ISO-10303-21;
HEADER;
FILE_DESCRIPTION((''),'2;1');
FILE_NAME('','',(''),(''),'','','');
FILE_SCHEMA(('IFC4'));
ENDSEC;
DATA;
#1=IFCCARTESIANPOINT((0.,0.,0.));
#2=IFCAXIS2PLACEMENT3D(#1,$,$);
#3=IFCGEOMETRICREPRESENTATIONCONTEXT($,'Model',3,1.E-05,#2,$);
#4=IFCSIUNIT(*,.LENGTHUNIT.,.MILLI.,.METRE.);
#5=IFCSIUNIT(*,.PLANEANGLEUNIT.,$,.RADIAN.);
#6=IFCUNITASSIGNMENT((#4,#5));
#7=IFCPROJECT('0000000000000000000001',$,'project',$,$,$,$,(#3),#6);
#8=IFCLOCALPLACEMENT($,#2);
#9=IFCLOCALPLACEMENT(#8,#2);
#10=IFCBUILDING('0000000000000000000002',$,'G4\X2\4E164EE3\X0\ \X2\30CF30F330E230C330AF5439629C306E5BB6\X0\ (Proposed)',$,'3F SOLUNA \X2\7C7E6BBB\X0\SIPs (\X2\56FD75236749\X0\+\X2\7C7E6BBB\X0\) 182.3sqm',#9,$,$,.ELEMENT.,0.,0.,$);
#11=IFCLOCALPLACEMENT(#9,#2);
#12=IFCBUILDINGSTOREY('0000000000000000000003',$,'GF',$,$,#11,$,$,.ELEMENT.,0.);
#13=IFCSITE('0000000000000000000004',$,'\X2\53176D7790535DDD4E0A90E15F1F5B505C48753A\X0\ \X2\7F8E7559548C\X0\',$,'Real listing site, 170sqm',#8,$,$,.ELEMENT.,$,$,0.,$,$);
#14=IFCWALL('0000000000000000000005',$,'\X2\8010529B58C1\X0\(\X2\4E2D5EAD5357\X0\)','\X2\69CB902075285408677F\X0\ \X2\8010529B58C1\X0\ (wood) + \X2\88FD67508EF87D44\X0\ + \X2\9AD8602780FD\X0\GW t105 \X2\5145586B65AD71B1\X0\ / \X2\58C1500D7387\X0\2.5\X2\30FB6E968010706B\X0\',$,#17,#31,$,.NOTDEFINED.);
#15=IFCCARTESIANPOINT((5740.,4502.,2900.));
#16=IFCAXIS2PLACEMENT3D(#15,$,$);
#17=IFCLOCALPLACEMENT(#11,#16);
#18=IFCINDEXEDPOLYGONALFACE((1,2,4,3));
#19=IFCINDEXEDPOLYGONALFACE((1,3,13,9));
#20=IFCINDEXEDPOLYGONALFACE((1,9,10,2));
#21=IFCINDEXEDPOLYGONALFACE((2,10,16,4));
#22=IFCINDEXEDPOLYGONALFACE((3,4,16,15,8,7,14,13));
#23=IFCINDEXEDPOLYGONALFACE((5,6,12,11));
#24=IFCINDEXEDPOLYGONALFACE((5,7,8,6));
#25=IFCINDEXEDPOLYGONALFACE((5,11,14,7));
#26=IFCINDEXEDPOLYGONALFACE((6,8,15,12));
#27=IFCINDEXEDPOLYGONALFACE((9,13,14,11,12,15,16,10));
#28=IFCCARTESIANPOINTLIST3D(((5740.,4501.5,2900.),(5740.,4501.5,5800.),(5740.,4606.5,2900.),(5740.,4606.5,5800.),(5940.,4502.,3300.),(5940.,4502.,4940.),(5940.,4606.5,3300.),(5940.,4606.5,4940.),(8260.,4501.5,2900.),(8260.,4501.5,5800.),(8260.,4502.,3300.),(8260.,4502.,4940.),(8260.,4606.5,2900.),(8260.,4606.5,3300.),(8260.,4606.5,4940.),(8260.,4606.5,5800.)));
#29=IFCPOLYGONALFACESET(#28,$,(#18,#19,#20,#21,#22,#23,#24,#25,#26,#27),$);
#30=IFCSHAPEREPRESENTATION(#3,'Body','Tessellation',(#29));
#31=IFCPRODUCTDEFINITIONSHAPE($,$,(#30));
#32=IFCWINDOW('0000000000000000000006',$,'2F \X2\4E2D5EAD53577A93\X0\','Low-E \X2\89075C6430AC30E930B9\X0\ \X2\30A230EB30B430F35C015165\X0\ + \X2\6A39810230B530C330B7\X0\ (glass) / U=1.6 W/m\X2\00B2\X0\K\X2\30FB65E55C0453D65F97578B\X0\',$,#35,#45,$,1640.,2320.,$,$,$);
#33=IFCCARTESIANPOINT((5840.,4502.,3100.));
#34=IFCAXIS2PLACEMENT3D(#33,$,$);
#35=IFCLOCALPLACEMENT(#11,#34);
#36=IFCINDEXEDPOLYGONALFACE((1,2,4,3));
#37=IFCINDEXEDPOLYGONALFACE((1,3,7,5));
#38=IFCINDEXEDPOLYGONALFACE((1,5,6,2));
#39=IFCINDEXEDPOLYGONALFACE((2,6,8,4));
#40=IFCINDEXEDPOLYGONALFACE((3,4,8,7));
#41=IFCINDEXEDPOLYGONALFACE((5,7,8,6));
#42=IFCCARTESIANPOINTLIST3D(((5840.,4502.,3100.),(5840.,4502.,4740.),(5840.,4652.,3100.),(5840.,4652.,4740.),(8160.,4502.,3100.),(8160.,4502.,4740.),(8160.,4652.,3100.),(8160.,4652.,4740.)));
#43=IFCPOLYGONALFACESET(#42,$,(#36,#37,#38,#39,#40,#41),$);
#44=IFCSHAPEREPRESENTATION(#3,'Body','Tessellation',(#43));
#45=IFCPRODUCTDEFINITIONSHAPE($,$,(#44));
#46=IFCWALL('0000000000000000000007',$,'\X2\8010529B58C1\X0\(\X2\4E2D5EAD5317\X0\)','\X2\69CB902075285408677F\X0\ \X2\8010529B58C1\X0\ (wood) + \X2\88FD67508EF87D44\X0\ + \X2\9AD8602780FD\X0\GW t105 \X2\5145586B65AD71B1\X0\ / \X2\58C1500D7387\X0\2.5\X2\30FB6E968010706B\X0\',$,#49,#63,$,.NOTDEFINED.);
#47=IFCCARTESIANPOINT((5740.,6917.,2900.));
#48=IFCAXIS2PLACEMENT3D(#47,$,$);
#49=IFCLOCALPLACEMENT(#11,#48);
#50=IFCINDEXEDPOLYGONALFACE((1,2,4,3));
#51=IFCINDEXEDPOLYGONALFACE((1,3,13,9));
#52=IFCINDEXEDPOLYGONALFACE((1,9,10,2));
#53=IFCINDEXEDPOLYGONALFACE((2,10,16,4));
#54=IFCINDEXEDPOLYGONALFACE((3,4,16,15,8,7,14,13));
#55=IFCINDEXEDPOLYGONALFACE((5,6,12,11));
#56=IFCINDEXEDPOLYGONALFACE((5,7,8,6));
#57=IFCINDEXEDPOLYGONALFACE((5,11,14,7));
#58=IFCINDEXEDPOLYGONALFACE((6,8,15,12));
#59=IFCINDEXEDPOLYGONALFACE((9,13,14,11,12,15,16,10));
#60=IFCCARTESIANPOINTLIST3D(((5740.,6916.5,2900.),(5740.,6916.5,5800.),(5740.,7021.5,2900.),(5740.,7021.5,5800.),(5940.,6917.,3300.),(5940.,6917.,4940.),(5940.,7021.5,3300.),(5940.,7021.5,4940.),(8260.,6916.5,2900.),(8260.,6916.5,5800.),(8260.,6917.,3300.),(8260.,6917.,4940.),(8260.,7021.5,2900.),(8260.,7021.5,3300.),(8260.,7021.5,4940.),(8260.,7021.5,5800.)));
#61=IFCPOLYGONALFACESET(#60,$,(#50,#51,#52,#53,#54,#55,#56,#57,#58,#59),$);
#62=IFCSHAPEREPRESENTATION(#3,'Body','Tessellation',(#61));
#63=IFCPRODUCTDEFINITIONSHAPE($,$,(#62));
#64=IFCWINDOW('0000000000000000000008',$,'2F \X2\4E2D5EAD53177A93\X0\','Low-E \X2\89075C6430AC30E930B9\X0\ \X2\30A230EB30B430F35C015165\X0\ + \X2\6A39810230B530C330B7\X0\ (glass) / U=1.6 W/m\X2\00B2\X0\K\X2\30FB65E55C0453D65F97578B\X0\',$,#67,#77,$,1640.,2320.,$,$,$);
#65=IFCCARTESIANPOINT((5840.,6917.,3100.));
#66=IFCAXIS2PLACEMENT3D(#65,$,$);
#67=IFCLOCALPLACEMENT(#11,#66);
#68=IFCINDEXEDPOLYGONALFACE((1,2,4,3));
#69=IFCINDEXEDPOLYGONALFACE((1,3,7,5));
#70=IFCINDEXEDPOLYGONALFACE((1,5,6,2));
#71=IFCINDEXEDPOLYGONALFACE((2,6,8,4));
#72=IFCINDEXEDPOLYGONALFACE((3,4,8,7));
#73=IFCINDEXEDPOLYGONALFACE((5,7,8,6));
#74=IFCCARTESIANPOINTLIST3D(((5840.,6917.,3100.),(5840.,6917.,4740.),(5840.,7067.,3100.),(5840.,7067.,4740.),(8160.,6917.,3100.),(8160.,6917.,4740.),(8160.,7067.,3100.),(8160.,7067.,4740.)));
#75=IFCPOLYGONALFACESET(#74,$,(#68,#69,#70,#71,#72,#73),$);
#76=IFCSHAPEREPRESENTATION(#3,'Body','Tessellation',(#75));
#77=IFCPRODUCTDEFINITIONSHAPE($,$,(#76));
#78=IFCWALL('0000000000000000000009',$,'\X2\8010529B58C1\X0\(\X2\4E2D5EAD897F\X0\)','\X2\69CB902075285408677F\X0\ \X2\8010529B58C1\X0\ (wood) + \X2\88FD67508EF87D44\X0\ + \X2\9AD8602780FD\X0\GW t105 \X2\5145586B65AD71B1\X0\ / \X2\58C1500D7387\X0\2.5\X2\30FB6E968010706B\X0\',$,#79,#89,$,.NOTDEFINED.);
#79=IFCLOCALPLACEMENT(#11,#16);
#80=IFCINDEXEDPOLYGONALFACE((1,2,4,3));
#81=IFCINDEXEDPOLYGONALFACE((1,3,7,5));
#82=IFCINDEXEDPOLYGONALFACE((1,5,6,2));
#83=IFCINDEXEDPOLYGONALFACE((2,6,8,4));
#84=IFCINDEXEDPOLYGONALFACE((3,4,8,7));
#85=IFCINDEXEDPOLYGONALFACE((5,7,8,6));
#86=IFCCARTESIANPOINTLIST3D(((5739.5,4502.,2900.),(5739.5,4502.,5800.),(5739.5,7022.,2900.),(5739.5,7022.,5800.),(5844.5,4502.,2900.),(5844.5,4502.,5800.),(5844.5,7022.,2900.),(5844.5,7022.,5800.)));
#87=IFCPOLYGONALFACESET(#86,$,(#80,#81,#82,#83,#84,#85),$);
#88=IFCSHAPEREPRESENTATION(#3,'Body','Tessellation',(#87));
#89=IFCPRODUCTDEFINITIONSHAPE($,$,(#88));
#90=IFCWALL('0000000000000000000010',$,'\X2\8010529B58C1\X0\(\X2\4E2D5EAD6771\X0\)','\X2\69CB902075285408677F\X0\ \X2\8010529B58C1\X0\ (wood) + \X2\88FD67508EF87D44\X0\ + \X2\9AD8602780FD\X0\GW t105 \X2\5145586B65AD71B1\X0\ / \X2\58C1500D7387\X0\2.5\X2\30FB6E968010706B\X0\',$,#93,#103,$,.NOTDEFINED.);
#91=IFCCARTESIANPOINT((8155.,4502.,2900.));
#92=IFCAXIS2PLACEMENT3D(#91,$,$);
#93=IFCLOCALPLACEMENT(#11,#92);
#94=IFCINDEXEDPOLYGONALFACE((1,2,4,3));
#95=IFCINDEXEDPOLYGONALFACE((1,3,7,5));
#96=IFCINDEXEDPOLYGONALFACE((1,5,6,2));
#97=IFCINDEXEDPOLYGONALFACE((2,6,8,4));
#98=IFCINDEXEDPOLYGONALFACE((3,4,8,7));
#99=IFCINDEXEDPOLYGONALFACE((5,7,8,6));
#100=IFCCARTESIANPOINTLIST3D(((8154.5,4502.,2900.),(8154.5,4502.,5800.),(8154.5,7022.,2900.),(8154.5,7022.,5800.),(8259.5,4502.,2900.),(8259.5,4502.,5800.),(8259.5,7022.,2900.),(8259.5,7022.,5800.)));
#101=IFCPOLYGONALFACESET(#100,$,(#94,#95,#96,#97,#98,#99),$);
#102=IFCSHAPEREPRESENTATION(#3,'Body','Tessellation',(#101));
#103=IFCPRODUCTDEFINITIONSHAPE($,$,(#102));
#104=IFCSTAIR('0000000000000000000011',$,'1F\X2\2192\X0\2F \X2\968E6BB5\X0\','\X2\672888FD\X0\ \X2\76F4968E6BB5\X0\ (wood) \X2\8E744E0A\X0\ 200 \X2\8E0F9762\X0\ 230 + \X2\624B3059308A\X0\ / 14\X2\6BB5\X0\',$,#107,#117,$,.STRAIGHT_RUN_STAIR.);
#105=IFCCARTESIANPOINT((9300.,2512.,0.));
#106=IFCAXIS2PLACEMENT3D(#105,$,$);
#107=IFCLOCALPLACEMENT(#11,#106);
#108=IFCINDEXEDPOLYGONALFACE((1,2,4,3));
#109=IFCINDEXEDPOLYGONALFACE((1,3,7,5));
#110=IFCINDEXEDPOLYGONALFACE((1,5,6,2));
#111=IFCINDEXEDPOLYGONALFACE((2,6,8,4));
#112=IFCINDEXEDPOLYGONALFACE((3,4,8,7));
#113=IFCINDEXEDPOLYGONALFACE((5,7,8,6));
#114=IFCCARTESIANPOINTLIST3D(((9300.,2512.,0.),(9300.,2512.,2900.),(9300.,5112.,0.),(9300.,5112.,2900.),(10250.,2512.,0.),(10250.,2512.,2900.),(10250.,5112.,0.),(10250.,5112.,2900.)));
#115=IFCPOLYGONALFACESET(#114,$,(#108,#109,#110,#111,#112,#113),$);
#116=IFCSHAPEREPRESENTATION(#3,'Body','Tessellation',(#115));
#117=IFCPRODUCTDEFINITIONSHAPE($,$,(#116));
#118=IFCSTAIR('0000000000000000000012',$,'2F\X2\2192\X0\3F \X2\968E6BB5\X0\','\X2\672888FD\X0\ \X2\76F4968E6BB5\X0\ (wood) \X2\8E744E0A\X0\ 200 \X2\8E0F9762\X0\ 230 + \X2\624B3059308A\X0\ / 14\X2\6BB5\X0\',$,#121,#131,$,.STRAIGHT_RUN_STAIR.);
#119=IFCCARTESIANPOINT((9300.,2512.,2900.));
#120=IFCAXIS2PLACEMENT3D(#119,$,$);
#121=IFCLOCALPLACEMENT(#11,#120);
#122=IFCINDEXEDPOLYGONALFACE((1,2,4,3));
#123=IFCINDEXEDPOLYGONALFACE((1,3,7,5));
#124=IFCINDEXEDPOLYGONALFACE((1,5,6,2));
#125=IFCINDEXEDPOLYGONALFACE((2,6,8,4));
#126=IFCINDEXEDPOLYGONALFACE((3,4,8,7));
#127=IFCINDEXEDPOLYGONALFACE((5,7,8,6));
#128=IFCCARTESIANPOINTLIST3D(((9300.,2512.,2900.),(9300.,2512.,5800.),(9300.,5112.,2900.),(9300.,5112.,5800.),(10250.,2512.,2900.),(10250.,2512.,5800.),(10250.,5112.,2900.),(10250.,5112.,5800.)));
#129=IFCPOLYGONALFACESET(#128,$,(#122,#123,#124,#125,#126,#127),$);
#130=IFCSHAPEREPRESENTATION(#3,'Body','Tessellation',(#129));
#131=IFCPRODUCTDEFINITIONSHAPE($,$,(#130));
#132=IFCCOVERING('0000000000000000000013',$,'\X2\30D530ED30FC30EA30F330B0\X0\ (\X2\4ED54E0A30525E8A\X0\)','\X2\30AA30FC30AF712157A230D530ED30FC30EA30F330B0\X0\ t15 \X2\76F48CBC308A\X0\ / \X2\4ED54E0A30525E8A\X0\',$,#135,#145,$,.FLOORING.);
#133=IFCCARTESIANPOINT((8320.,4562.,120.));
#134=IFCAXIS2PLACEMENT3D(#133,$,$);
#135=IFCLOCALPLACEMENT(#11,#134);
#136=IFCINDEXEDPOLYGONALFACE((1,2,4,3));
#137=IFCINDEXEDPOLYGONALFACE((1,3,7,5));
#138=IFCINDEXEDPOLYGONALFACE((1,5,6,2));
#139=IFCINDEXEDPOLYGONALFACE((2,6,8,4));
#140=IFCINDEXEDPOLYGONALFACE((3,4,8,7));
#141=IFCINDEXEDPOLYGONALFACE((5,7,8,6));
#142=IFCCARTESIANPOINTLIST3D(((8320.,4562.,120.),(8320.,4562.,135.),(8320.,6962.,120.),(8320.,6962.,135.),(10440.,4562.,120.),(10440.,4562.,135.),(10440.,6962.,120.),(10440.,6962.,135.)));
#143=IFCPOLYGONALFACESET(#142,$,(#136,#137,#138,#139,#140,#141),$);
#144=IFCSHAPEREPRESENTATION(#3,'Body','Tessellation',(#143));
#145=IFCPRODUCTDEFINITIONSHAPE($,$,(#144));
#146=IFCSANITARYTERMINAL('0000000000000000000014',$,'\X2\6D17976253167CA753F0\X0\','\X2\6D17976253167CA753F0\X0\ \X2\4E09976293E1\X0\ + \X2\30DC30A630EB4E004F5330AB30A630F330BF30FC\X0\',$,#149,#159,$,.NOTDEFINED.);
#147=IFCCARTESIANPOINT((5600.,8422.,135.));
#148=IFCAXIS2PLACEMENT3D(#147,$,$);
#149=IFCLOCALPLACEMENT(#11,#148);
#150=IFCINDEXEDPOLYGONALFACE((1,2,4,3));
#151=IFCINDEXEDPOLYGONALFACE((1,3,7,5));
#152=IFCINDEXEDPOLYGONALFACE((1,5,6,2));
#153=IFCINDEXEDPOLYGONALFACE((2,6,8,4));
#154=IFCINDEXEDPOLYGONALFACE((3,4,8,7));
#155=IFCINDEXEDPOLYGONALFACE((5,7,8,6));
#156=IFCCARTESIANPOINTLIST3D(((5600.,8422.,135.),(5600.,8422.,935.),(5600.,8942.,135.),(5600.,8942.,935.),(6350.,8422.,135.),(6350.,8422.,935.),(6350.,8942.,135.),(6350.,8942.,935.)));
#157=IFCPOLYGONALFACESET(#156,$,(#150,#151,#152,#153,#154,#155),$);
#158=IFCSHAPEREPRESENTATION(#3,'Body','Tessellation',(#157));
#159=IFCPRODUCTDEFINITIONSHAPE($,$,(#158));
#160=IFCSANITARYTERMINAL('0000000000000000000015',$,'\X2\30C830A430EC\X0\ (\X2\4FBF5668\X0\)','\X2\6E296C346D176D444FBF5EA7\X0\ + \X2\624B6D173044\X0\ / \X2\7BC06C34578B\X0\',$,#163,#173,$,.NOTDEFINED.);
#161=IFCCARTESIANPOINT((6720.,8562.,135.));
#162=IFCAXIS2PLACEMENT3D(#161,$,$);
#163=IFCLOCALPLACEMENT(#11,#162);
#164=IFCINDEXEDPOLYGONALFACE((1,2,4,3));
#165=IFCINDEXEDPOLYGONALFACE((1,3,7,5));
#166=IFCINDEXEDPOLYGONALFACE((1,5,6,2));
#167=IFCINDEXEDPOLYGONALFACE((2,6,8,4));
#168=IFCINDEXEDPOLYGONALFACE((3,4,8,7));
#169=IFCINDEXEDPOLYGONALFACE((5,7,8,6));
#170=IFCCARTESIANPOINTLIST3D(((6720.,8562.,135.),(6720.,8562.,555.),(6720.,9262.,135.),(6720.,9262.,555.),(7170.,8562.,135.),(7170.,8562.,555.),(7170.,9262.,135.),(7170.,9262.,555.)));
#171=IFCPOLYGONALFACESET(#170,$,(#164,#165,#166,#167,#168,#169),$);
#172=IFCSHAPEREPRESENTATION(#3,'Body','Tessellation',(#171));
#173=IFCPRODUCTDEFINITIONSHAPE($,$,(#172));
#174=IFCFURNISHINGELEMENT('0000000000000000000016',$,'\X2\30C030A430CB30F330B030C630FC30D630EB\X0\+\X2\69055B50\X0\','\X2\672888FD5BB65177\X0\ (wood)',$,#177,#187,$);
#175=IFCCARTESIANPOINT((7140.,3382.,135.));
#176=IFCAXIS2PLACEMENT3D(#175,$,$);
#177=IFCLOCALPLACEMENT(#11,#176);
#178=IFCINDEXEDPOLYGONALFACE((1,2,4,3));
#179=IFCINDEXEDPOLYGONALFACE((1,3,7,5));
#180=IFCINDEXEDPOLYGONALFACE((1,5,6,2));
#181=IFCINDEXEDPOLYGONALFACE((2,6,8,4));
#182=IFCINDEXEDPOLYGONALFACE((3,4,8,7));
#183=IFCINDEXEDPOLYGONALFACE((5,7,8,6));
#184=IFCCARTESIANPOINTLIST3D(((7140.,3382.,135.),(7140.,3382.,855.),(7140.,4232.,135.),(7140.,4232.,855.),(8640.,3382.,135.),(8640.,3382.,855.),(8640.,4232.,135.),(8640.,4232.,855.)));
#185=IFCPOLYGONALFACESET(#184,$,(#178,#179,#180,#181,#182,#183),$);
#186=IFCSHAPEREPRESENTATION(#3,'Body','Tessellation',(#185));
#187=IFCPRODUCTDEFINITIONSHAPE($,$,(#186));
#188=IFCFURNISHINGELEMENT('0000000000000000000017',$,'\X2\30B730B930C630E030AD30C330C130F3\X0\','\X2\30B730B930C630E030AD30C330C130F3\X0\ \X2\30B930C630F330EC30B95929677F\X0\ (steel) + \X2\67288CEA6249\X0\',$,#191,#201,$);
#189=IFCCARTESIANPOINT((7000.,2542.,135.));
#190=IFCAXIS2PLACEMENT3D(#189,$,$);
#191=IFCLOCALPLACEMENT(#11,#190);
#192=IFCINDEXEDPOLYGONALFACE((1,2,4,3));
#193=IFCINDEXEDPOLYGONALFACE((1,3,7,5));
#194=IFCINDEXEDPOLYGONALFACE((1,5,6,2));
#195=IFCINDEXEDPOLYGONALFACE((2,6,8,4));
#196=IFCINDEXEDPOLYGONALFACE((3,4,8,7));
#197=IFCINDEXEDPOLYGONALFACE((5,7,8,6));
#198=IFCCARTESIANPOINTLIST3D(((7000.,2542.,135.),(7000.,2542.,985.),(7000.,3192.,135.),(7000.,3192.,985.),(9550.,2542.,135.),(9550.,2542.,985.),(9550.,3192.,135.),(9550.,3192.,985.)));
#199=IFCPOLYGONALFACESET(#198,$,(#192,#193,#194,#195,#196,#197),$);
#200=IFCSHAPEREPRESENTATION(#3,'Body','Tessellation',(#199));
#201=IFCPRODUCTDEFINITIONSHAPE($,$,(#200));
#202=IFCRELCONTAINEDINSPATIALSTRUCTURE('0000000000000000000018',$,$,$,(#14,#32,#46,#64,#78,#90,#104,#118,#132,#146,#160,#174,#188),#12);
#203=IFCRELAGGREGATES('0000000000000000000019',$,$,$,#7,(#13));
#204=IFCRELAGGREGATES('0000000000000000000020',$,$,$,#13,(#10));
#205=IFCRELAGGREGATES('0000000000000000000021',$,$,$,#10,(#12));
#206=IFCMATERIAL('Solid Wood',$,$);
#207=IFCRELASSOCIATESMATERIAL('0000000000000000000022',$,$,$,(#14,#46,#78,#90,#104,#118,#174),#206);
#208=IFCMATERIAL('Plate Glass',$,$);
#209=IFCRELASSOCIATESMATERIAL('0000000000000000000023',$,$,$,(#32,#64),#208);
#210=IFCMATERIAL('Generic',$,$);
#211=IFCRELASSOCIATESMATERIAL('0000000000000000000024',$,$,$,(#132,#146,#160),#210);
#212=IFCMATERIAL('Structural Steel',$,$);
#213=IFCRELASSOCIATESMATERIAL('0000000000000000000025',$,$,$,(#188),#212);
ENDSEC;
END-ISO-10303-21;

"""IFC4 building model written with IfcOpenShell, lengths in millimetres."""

from ifc_helpers import new_model, si_unit, frame, frame_2d, origin, place, context, project, spatial, rectangle, extrude, material, element, fill, save


model = new_model("IFC4")

# Units and contexts
model_context = context("Model", 3, precision=1e-05, world=origin())
ifc_project = project(units=[si_unit("LENGTHUNIT", "METRE", prefix="MILLI"), si_unit("PLANEANGLEUNIT", "RADIAN")], contexts=[model_context])

# Site, building, storey
site_placement = place(None, origin())
site = spatial("IfcSite", under=ifc_project, at=site_placement, Name="北海道川上郡弟子屈町 美留和", ObjectType="Real listing site, 170sqm", CompositionType="ELEMENT", RefElevation=0.0)
building_placement = place(site_placement, origin())
building = spatial("IfcBuilding", under=site, at=building_placement, Name="G4世代 ハンモック吹抜の家 (Proposed)", ObjectType="3F SOLUNA 籾殻SIPs (国産杉+籾殻) 182.3sqm", CompositionType="ELEMENT", ElevationOfRefHeight=0.0, ElevationOfTerrain=0.0)
storey_placement = place(building_placement, origin())
storey = spatial("IfcBuildingStorey", under=building, at=storey_placement, Name="GF", CompositionType="ELEMENT", Elevation=0.0)

# Shared definitions
ifc_material_1 = material(Name="Solid Wood")

# Shared definitions
ifc_material_2 = material(Name="Plate Glass")

# Walls, openings, windows
wall_1_placement = place(storey_placement, frame((5740.0, 4502.0, 2900.0)))
wall_1 = element("IfcWall", 1, at=wall_1_placement, inside=storey, material=ifc_material_1, Name="耐力壁(中庭南)", Description="構造用合板 耐力壁 (wood) + 製材軸組 + 高性能GW t105 充填断熱 / 壁倍率2.5・準耐火", PredefinedType="NOTDEFINED", context=model_context, shape_type="SweptSolid", body=[
    extrude(rectangle(XDim=2520.0, YDim=105.0, at=frame_2d((1260.0, 52.0))), frame((5740.0, 4502.0, 2900.0)), (0.0, 0.0, 1.0), 2900.0),
])
opening_1_placement = place(storey_placement, frame((5840.0, 4502.0, 3100.0)))
opening_1 = element("IfcOpeningElement", 2, at=opening_1_placement, cuts=wall_1, PredefinedType="NOTDEFINED", context=model_context, shape_type="SweptSolid", body=[
    extrude(rectangle(XDim=2320.0, YDim=150.0, at=frame_2d((1160.0, 75.0))), frame((5840.0, 4502.0, 3100.0)), (0.0, 0.0, 1.0), 1640.0),
])
window_1_placement = place(storey_placement, frame((5840.0, 4502.0, 3100.0)))
window_1 = element("IfcWindow", 3, at=window_1_placement, inside=storey, material=ifc_material_2, Name="2F 中庭南窓", Description="Low-E 複層ガラス アルゴン封入 + 樹脂サッシ (glass) / U=1.6 W/m²K・日射取得型", OverallHeight=1640.0, OverallWidth=2320.0, context=model_context, shape_type="SweptSolid", body=[
    extrude(rectangle(XDim=2320.0, YDim=150.0, at=frame_2d((1160.0, 75.0))), frame((5840.0, 4502.0, 3100.0)), (0.0, 0.0, 1.0), 1640.0),
])
fill(opening_1, window_1)
wall_2_placement = place(storey_placement, frame((5740.0, 6917.0, 2900.0)))
wall_2 = element("IfcWall", 4, at=wall_2_placement, inside=storey, material=ifc_material_1, Name="耐力壁(中庭北)", Description="構造用合板 耐力壁 (wood) + 製材軸組 + 高性能GW t105 充填断熱 / 壁倍率2.5・準耐火", PredefinedType="NOTDEFINED", context=model_context, shape_type="SweptSolid", body=[
    extrude(rectangle(XDim=2520.0, YDim=105.0, at=frame_2d((1260.0, 52.0))), frame((5740.0, 6917.0, 2900.0)), (0.0, 0.0, 1.0), 2900.0),
])
opening_2_placement = place(storey_placement, frame((5840.0, 6917.0, 3100.0)))
opening_2 = element("IfcOpeningElement", 5, at=opening_2_placement, cuts=wall_2, PredefinedType="NOTDEFINED", context=model_context, shape_type="SweptSolid", body=[
    extrude(rectangle(XDim=2320.0, YDim=150.0, at=frame_2d((1160.0, 75.0))), frame((5840.0, 6917.0, 3100.0)), (0.0, 0.0, 1.0), 1640.0),
])
window_2_placement = place(storey_placement, frame((5840.0, 6917.0, 3100.0)))
window_2 = element("IfcWindow", 6, at=window_2_placement, inside=storey, material=ifc_material_2, Name="2F 中庭北窓", Description="Low-E 複層ガラス アルゴン封入 + 樹脂サッシ (glass) / U=1.6 W/m²K・日射取得型", OverallHeight=1640.0, OverallWidth=2320.0, context=model_context, shape_type="SweptSolid", body=[
    extrude(rectangle(XDim=2320.0, YDim=150.0, at=frame_2d((1160.0, 75.0))), frame((5840.0, 6917.0, 3100.0)), (0.0, 0.0, 1.0), 1640.0),
])
fill(opening_2, window_2)

# Walls
wall_3_placement = place(storey_placement, frame((5740.0, 4502.0, 2900.0)))
element("IfcWall", 7, at=wall_3_placement, inside=storey, material=ifc_material_1, Name="耐力壁(中庭西)", Description="構造用合板 耐力壁 (wood) + 製材軸組 + 高性能GW t105 充填断熱 / 壁倍率2.5・準耐火", PredefinedType="NOTDEFINED", context=model_context, shape_type="SweptSolid", body=[
    extrude(rectangle(XDim=105.0, YDim=2520.0, at=frame_2d((52.0, 1260.0))), frame((5740.0, 4502.0, 2900.0)), (0.0, 0.0, 1.0), 2900.0),
])
wall_4_placement = place(storey_placement, frame((8155.0, 4502.0, 2900.0)))
element("IfcWall", 8, at=wall_4_placement, inside=storey, material=ifc_material_1, Name="耐力壁(中庭東)", Description="構造用合板 耐力壁 (wood) + 製材軸組 + 高性能GW t105 充填断熱 / 壁倍率2.5・準耐火", PredefinedType="NOTDEFINED", context=model_context, shape_type="SweptSolid", body=[
    extrude(rectangle(XDim=105.0, YDim=2520.0, at=frame_2d((52.0, 1260.0))), frame((8155.0, 4502.0, 2900.0)), (0.0, 0.0, 1.0), 2900.0),
])

# Stairs
stair_1_placement = place(storey_placement, frame((9300.0, 2512.0, 0.0)))
element("IfcStair", 9, at=stair_1_placement, inside=storey, material=ifc_material_1, Name="1F→2F 階段", Description="木製 直階段 (wood) 蹴上 200 踏面 230 + 手すり / 14段", PredefinedType="STRAIGHT_RUN_STAIR", context=model_context, shape_type="SweptSolid", body=[
    extrude(rectangle(XDim=950.0, YDim=2600.0, at=frame_2d((475.0, 1300.0))), frame((9300.0, 2512.0, 0.0)), (0.0, 0.0, 1.0), 2900.0),
])
stair_2_placement = place(storey_placement, frame((9300.0, 2512.0, 2900.0)))
element("IfcStair", 10, at=stair_2_placement, inside=storey, material=ifc_material_1, Name="2F→3F 階段", Description="木製 直階段 (wood) 蹴上 200 踏面 230 + 手すり / 14段", PredefinedType="STRAIGHT_RUN_STAIR", context=model_context, shape_type="SweptSolid", body=[
    extrude(rectangle(XDim=950.0, YDim=2600.0, at=frame_2d((475.0, 1300.0))), frame((9300.0, 2512.0, 2900.0)), (0.0, 0.0, 1.0), 2900.0),
])

# Covering
ifc_material_3 = material(Name="Generic")
covering_placement = place(storey_placement, frame((8320.0, 4562.0, 120.0)))
element("IfcCovering", 11, at=covering_placement, inside=storey, material=ifc_material_3, Name="フローリング (仕上げ床)", Description="オーク無垢フローリング t15 直貼り / 仕上げ床", PredefinedType="FLOORING", context=model_context, shape_type="SweptSolid", body=[
    extrude(rectangle(XDim=2120.0, YDim=2400.0, at=frame_2d((1060.0, 1200.0))), frame((8320.0, 4562.0, 120.0)), (0.0, 0.0, 1.0), 15.0),
])

# Sanitary terminals
sanitary_terminal_1_placement = place(storey_placement, frame((5600.0, 8422.0, 135.0)))
element("IfcSanitaryTerminal", 12, at=sanitary_terminal_1_placement, inside=storey, material=ifc_material_3, Name="洗面化粧台", Description="洗面化粧台 三面鏡 + ボウル一体カウンター", PredefinedType="NOTDEFINED", context=model_context, shape_type="SweptSolid", body=[
    extrude(rectangle(XDim=750.0, YDim=520.0, at=frame_2d((375.0, 260.0))), frame((5600.0, 8422.0, 135.0)), (0.0, 0.0, 1.0), 800.0),
])
sanitary_terminal_2_placement = place(storey_placement, frame((6720.0, 8562.0, 135.0)))
element("IfcSanitaryTerminal", 13, at=sanitary_terminal_2_placement, inside=storey, material=ifc_material_3, Name="トイレ (便器)", Description="温水洗浄便座 + 手洗い / 節水型", PredefinedType="NOTDEFINED", context=model_context, shape_type="SweptSolid", body=[
    extrude(rectangle(XDim=450.0, YDim=700.0, at=frame_2d((225.0, 350.0))), frame((6720.0, 8562.0, 135.0)), (0.0, 0.0, 1.0), 420.0),
])

# Furnishing elements
furnishing_1_placement = place(storey_placement, frame((7140.0, 3382.0, 135.0)))
element("IfcFurnishingElement", 14, at=furnishing_1_placement, inside=storey, material=ifc_material_1, Name="ダイニングテーブル+椅子", Description="木製家具 (wood)", context=model_context, shape_type="SweptSolid", body=[
    extrude(rectangle(XDim=1500.0, YDim=850.0, at=frame_2d((750.0, 425.0))), frame((7140.0, 3382.0, 135.0)), (0.0, 0.0, 1.0), 720.0),
])
ifc_material_4 = material(Name="Structural Steel")
furnishing_2_placement = place(storey_placement, frame((7000.0, 2542.0, 135.0)))
element("IfcFurnishingElement", 15, at=furnishing_2_placement, inside=storey, material=ifc_material_4, Name="システムキッチン", Description="システムキッチン ステンレス天板 (steel) + 木質扉", context=model_context, shape_type="SweptSolid", body=[
    extrude(rectangle(XDim=2550.0, YDim=650.0, at=frame_2d((1275.0, 325.0))), frame((7000.0, 2542.0, 135.0)), (0.0, 0.0, 1.0), 850.0),
])

save(model, "model.ifc")
